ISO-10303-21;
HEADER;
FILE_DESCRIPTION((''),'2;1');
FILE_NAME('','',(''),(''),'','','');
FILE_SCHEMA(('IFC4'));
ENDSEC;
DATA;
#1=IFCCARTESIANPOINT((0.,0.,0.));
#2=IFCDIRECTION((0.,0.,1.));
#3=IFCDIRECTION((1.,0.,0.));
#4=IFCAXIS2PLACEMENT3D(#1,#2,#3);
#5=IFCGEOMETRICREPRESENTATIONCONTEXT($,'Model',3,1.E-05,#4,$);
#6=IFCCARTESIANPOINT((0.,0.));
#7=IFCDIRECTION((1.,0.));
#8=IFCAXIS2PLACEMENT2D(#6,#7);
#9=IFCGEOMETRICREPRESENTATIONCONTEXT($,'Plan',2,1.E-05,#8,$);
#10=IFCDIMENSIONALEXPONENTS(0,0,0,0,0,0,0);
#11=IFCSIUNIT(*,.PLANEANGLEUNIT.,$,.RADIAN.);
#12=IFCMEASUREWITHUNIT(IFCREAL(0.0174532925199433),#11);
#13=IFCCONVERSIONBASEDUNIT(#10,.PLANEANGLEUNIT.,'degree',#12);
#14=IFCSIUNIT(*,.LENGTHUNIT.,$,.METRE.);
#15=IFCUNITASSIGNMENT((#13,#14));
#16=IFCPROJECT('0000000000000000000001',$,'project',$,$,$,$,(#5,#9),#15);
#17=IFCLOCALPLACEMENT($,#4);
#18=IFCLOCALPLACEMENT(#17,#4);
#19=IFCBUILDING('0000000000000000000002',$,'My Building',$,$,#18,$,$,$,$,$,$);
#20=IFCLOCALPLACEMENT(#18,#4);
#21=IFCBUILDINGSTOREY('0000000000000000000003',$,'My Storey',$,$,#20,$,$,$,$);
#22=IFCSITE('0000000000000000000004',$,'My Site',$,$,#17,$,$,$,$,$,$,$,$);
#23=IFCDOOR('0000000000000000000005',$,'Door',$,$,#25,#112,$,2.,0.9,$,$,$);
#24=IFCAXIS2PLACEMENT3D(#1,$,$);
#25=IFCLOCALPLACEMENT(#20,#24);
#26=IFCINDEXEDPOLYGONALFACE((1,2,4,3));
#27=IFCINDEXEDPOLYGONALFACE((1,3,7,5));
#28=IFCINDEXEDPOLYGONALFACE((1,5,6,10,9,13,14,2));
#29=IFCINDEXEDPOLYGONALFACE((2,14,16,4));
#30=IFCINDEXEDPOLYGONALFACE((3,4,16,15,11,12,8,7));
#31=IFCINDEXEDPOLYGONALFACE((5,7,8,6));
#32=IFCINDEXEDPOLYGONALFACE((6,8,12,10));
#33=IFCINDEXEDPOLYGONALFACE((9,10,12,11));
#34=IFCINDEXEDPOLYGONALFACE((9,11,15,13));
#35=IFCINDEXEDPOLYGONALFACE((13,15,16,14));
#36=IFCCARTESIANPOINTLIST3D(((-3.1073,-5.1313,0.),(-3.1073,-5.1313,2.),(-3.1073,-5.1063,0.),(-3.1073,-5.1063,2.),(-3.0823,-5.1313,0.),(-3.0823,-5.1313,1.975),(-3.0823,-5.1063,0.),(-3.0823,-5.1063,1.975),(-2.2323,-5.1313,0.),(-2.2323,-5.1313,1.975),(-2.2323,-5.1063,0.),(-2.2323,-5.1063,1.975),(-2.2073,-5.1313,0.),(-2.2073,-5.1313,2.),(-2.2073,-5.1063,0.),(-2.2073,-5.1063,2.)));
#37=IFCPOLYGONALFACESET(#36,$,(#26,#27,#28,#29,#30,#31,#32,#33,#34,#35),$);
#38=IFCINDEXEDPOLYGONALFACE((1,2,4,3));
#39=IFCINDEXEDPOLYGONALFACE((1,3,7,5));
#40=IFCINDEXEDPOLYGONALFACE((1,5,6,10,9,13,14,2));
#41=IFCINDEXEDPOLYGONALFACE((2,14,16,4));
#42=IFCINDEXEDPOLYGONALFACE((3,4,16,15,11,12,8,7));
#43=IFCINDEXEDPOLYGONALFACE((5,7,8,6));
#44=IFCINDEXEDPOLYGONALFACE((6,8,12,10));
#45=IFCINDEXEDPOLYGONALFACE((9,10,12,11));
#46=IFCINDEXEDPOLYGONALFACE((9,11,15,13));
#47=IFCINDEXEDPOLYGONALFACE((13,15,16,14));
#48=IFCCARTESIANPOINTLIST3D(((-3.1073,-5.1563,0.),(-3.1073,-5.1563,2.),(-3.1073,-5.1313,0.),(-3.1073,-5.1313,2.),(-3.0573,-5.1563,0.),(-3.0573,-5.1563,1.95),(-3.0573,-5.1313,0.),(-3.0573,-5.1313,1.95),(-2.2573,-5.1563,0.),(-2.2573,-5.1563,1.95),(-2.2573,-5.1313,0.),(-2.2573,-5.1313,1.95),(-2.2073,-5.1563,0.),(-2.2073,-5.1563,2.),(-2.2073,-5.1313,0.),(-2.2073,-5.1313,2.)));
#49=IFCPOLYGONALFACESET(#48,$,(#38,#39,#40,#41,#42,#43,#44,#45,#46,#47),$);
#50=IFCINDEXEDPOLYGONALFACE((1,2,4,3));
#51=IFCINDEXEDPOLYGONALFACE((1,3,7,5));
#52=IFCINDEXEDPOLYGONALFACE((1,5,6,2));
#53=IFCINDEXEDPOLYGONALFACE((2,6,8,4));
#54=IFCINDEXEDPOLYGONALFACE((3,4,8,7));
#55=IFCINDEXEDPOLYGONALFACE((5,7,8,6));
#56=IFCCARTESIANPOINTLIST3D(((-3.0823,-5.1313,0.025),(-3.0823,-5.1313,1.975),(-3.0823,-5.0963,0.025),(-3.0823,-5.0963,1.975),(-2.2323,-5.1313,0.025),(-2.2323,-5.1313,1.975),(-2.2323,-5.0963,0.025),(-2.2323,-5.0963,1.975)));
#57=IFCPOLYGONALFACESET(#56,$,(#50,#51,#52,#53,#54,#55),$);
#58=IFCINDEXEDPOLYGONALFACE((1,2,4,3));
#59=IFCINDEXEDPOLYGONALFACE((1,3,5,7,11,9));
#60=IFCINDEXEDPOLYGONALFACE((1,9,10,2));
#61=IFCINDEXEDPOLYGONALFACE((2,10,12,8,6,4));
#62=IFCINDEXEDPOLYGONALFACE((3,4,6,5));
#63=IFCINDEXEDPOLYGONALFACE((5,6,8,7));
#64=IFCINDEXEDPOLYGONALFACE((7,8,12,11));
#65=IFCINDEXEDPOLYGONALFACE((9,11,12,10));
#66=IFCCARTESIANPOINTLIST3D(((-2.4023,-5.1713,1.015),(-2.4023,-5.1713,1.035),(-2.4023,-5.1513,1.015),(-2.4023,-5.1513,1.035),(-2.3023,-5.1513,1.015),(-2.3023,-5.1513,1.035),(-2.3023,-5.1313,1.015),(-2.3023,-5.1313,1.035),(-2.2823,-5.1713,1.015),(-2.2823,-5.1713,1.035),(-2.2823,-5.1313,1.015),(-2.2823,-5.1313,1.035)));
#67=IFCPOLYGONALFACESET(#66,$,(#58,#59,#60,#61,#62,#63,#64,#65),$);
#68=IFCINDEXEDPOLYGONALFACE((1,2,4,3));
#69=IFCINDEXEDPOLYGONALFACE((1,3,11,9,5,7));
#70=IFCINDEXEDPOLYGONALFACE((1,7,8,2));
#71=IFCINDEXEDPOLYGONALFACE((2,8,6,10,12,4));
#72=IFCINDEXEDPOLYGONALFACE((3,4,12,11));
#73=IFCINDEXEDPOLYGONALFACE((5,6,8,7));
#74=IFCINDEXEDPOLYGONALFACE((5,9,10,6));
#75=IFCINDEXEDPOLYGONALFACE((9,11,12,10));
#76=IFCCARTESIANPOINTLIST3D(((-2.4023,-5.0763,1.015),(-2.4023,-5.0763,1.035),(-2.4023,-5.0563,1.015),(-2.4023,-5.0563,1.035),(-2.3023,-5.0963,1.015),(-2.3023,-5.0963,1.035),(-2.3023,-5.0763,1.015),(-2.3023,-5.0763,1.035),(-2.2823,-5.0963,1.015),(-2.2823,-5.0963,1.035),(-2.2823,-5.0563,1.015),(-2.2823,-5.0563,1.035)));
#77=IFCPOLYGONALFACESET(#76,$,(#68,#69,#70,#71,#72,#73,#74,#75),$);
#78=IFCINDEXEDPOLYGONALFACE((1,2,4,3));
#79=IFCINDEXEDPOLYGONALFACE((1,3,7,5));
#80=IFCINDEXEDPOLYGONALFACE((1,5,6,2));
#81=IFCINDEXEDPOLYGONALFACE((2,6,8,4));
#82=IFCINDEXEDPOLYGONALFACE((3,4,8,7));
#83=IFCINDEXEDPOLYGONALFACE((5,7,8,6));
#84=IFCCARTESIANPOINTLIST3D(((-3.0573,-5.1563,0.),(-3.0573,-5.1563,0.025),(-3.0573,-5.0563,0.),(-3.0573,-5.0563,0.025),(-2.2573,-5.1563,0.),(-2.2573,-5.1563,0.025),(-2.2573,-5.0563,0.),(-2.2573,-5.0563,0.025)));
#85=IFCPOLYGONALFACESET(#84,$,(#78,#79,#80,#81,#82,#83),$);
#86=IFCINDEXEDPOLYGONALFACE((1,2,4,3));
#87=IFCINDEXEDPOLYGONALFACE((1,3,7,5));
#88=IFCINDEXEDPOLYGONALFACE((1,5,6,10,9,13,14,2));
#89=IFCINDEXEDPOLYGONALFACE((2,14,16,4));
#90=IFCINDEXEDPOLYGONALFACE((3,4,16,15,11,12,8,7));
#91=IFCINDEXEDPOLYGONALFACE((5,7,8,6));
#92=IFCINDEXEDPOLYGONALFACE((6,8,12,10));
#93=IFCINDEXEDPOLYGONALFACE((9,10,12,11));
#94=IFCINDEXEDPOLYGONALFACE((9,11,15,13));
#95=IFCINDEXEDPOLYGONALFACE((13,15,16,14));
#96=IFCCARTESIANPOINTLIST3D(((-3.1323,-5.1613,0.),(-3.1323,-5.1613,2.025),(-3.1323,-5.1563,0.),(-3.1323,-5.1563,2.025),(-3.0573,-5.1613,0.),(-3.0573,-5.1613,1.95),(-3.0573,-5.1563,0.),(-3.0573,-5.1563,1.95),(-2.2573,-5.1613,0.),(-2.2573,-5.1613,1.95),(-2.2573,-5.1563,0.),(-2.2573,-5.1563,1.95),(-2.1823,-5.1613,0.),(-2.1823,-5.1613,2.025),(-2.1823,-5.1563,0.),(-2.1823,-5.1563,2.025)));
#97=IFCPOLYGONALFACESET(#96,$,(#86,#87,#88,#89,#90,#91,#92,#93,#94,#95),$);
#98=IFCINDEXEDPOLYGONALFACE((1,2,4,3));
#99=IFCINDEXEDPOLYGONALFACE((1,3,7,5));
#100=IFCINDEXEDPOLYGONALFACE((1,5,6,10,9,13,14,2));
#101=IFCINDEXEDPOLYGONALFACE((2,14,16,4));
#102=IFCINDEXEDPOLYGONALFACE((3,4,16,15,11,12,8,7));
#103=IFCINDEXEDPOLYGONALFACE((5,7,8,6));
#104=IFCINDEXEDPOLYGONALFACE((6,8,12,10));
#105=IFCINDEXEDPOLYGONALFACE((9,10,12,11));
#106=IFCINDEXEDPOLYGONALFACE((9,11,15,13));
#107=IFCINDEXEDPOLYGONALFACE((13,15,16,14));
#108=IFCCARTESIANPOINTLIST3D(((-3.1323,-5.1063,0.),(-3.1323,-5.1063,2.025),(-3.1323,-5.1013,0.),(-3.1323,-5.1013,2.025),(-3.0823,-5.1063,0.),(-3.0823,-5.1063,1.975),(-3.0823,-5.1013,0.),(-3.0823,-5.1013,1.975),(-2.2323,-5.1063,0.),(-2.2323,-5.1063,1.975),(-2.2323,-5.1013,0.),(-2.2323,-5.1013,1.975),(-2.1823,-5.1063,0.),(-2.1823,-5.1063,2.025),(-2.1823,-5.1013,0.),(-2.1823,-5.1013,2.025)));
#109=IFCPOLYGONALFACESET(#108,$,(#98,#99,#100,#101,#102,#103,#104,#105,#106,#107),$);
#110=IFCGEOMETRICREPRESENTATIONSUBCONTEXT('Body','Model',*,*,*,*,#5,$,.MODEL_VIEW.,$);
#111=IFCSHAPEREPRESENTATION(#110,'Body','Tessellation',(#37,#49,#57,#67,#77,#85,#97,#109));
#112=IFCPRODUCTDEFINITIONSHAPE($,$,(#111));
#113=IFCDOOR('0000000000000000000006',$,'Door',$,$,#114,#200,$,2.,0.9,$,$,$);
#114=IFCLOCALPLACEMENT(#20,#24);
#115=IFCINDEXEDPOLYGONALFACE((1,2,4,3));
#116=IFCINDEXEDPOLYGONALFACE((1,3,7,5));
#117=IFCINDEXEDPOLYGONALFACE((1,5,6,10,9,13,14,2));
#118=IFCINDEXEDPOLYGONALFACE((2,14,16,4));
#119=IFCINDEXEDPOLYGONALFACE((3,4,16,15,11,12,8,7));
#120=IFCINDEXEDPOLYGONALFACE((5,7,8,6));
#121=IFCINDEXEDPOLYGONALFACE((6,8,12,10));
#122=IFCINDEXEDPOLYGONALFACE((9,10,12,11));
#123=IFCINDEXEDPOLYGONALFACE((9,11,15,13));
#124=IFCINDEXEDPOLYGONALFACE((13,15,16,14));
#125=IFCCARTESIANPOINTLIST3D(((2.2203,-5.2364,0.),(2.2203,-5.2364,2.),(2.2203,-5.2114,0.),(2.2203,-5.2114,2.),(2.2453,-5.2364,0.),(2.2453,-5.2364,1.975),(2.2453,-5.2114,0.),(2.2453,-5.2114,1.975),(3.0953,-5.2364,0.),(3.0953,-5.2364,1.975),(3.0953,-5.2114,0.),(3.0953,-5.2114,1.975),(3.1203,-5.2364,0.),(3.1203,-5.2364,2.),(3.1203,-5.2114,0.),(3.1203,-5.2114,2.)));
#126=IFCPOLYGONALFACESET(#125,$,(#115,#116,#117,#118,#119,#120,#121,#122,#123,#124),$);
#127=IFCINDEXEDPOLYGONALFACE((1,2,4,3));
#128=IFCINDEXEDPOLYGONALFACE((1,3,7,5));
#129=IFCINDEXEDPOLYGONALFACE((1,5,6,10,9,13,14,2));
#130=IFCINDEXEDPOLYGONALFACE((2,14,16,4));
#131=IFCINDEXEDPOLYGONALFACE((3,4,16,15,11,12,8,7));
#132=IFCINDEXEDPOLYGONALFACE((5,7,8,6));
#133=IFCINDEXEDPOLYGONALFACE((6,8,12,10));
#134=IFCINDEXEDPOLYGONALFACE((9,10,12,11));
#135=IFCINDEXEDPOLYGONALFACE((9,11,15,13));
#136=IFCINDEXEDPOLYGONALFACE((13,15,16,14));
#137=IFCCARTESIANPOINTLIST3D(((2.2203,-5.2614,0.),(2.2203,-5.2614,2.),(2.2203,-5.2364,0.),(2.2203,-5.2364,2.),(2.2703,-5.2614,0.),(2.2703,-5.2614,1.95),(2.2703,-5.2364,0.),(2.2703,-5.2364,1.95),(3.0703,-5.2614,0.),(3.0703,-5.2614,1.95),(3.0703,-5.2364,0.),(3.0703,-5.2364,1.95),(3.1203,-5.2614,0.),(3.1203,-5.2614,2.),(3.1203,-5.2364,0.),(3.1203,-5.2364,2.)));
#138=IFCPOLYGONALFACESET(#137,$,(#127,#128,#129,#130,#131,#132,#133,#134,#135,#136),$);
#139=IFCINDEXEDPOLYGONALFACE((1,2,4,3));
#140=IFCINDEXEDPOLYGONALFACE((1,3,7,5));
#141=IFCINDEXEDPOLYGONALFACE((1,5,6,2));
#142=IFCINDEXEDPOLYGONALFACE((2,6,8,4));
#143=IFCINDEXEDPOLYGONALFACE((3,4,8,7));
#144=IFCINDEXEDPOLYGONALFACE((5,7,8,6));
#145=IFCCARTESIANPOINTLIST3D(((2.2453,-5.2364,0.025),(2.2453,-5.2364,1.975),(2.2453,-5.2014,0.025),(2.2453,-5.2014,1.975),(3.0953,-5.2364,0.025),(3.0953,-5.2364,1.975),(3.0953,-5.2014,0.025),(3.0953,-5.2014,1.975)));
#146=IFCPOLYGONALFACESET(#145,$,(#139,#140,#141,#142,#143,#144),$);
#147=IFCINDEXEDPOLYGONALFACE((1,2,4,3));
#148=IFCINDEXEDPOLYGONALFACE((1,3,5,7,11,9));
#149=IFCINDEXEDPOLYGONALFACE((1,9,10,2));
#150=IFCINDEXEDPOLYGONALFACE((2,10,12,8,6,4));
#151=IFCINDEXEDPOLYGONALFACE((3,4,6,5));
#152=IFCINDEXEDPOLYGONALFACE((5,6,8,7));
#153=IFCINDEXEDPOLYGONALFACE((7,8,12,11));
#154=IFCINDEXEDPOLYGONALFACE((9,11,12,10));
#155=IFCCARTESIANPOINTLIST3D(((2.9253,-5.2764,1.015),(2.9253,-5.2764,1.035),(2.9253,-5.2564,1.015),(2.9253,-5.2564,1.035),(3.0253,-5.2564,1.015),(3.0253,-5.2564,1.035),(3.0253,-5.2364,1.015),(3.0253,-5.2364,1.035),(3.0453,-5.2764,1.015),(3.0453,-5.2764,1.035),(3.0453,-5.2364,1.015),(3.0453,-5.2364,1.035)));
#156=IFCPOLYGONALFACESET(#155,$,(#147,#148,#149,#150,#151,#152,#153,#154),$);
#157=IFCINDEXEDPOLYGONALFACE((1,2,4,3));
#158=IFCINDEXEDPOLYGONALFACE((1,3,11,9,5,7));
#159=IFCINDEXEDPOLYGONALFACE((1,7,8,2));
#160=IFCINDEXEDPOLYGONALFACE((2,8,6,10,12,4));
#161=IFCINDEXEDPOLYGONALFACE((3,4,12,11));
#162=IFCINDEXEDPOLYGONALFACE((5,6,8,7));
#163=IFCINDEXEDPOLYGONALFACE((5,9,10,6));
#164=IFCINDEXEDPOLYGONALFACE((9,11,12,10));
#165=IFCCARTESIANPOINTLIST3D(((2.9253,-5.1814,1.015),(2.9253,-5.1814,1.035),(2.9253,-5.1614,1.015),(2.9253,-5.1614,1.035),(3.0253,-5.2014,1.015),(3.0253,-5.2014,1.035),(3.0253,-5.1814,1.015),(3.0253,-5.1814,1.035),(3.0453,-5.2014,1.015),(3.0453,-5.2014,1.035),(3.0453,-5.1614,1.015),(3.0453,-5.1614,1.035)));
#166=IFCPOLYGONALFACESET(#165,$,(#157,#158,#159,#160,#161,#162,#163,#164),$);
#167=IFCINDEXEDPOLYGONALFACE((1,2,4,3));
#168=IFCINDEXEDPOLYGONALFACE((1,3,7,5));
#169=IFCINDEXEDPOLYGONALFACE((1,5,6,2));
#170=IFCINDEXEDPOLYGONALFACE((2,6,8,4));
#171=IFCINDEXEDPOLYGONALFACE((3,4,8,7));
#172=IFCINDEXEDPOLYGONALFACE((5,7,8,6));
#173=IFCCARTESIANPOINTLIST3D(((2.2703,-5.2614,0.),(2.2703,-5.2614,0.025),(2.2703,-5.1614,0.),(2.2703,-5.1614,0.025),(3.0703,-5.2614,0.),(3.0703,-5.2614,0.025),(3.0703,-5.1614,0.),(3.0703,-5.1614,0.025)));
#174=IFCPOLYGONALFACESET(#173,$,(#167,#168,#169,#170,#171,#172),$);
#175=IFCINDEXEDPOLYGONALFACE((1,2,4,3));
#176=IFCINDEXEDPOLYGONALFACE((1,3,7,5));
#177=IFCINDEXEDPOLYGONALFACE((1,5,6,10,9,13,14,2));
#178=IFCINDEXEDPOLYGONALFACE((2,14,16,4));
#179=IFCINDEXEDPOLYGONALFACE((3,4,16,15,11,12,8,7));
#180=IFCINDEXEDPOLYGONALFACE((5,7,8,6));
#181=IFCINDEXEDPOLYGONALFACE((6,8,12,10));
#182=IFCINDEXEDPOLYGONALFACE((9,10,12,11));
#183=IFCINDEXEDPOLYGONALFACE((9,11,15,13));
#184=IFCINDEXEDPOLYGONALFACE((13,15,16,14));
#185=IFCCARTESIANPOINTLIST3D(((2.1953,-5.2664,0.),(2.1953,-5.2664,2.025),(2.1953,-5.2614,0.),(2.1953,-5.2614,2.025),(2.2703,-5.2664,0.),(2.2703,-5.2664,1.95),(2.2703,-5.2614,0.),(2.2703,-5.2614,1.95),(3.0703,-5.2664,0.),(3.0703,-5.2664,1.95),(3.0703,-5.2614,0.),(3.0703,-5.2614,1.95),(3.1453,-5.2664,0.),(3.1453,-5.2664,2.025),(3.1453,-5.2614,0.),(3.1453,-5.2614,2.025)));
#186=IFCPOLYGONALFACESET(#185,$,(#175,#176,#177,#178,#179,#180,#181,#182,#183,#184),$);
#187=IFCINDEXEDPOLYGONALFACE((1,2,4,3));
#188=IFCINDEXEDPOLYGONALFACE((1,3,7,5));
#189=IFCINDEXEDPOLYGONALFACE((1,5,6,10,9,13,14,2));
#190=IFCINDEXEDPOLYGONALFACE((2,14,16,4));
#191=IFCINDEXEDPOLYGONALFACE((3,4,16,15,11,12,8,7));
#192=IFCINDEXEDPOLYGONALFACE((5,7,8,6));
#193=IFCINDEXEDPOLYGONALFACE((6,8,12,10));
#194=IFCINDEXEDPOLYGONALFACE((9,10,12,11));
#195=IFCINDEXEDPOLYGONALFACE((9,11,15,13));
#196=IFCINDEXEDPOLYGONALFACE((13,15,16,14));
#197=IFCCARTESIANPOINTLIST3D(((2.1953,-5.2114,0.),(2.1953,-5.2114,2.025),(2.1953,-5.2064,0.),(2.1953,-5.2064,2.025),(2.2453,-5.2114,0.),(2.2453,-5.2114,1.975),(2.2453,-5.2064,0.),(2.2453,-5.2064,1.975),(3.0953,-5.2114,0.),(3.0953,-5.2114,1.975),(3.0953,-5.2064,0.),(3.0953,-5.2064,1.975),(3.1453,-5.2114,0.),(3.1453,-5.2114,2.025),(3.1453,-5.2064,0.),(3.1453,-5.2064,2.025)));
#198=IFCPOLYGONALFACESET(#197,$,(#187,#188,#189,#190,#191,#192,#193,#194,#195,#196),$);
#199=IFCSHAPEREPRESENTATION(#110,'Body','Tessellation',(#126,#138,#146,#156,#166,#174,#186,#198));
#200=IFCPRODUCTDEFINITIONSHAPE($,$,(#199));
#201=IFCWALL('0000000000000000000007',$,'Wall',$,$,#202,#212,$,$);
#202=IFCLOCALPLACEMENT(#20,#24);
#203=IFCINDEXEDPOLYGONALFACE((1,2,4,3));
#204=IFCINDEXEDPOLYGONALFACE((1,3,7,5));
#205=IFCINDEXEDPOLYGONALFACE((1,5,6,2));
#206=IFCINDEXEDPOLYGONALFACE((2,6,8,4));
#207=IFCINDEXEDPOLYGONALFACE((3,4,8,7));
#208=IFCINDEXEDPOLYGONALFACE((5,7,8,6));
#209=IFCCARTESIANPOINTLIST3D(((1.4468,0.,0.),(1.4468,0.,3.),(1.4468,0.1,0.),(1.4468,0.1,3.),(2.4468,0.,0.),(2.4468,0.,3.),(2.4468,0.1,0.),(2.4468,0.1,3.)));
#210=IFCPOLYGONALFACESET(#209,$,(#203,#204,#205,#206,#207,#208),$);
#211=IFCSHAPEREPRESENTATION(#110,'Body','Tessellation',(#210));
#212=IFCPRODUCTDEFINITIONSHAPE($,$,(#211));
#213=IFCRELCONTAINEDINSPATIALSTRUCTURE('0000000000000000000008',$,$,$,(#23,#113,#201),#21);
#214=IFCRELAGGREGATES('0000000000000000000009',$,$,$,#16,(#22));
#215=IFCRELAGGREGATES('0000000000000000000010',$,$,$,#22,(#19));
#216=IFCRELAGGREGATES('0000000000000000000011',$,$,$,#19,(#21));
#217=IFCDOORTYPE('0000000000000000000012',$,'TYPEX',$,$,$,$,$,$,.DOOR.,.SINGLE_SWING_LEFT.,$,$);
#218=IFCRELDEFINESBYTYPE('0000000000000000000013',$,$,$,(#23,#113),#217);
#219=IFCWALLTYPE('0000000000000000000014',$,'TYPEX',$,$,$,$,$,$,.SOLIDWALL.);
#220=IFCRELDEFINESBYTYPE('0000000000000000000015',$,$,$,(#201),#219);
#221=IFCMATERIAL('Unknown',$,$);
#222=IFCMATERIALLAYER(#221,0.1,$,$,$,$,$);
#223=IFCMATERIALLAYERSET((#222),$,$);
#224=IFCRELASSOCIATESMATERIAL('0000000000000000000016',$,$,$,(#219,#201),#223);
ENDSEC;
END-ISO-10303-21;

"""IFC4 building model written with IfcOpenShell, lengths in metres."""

from ifc_helpers import new_model, entity, si_unit, converted_unit, frame, origin_with_axes, origin_2d_with_axis, place, context, subcontext, project, spatial, line, indexed_curve, outline, extrude, shape, source, transform, mapped, material, layer, layer_set, layer_usage, type_object, type_shapes, element, save


model = new_model("IFC4")

# Units and contexts
model_context = context("Model", 3, precision=1e-05, world=origin_with_axes())
plan_context = context("Plan", 2, precision=1e-05, world=origin_2d_with_axis())
body_context_1 = subcontext(model_context, "Body", "Model", "MODEL_VIEW")
body_context_2 = subcontext(plan_context, "Body", "Plan", "PLAN_VIEW")
ifc_project = project(units=[converted_unit("PLANEANGLEUNIT", "degree", entity("IfcReal", 0.0174532925199433), si_unit("PLANEANGLEUNIT", "RADIAN"), dimensions=[0, 0, 0, 0, 0, 0, 0]), si_unit("LENGTHUNIT", "METRE")], contexts=[model_context, plan_context])

# Site, building, storey
site_placement = place(None, origin_with_axes())
site = spatial("IfcSite", under=ifc_project, at=site_placement, Name="My Site")
building_placement = place(site_placement, origin_with_axes())
building = spatial("IfcBuilding", under=site, at=building_placement, Name="My Building")
storey_placement = place(building_placement, origin_with_axes())
storey = spatial("IfcBuildingStorey", under=building, at=storey_placement, Name="My Storey")

# Doors
door_type = type_object("IfcDoorType", Name="TYPEX", OperationType="SINGLE_SWING_LEFT", PredefinedType="DOOR")
shared_shape_1 = source(origin_with_axes(), body_context_1, "Body", "SweptSolid", [
    extrude(outline(indexed_curve([(0.0, 0.0), (0.0, 2.0), (0.9, 2.0), (0.9, 0.0), (0.875, 0.0), (0.875, 1.975), (0.025, 1.975), (0.025, 0.0)], segments=[line(1, 2, 3, 4, 5, 6, 7, 8, 1)])), frame((0.0, 0.025, 0.0), z_axis=(0.0, -1.0, 0.0), x_axis=(1.0, 0.0, 0.0)), (0.0, 0.0, -1.0), 0.025),
    extrude(outline(indexed_curve([(0.0, 0.0), (0.0, 2.0), (0.9, 2.0), (0.9, 0.0), (0.85, 0.0), (0.85, 1.95), (0.05, 1.95), (0.05, 0.0)], segments=[line(1, 2, 3, 4, 5, 6, 7, 8, 1)])), frame((0.0, 0.0, 0.0), z_axis=(0.0, -1.0, 0.0), x_axis=(1.0, 0.0, 0.0)), (0.0, 0.0, -1.0), 0.025),
    extrude(outline(indexed_curve([(0.0, 0.0), (0.85, 0.0), (0.85, 0.035), (0.0, 0.035)], segments=[line(1, 2, 3, 4, 1)])), frame((0.025, 0.025, 0.025), z_axis=(0.0, 0.0, 1.0), x_axis=(1.0, 0.0, 0.0)), (0.0, 0.0, 1.0), 1.95),
    extrude(outline(indexed_curve([(0.0, 0.0), (0.0, -0.04), (-0.12, -0.04), (-0.12, -0.02), (-0.02, -0.02), (-0.02, 0.0)], segments=[line(1, 2, 3, 4, 5, 6, 1)])), frame((0.825, 0.025, 1.015), z_axis=(0.0, 0.0, 1.0), x_axis=(1.0, 0.0, 0.0)), (0.0, 0.0, 1.0), 0.02),
    extrude(outline(indexed_curve([(0.0, 0.0), (0.0, 0.04), (-0.12, 0.04), (-0.12, 0.02), (-0.02, 0.02), (-0.02, 0.0)], segments=[line(1, 2, 3, 4, 5, 6, 1)])), frame((0.825, 0.06, 1.015), z_axis=(0.0, 0.0, 1.0), x_axis=(1.0, 0.0, 0.0)), (0.0, 0.0, 1.0), 0.02),
    extrude(outline(indexed_curve([(0.0, 0.0), (0.8, 0.0), (0.8, 0.1), (0.0, 0.1)], segments=[line(1, 2, 3, 4, 1)])), frame((0.05, 0.0, 0.0), z_axis=(0.0, 0.0, 1.0), x_axis=(1.0, 0.0, 0.0)), (0.0, 0.0, 1.0), 0.025),
    extrude(outline(indexed_curve([(0.0, 0.0), (0.0, 2.025), (0.95, 2.025), (0.95, 0.0), (0.875, 0.0), (0.875, 1.95), (0.075, 1.95), (0.075, 0.0)], segments=[line(1, 2, 3, 4, 5, 6, 7, 8, 1)])), frame((-0.025, -0.005, 0.0), z_axis=(0.0, -1.0, 0.0), x_axis=(1.0, 0.0, 0.0)), (0.0, 0.0, -1.0), 0.005),
    extrude(outline(indexed_curve([(0.0, 0.0), (0.0, 2.025), (0.95, 2.025), (0.95, 0.0), (0.9, 0.0), (0.9, 1.975), (0.05, 1.975), (0.05, 0.0)], segments=[line(1, 2, 3, 4, 5, 6, 7, 8, 1)])), frame((-0.025, 0.05, 0.0), z_axis=(0.0, -1.0, 0.0), x_axis=(1.0, 0.0, 0.0)), (0.0, 0.0, -1.0), 0.005),
])
shared_shape_2 = source(origin_with_axes(), body_context_2, "Body", "Curve2D", [
    entity("IfcIndexedPolyCurve", entity("IfcCartesianPointList2D", [[0.0, 0.0], [0.0, 0.05], [0.025, 0.05], [0.025, 0.025], [0.05, 0.025], [0.05, 0.0]]), [entity("IfcLineIndex", [1, 2, 3, 4, 5, 6, 1])]),
    entity("IfcIndexedPolyCurve", entity("IfcCartesianPointList2D", [[0.9, 0.0], [0.9, 0.05], [0.875, 0.05], [0.875, 0.025], [0.85, 0.025], [0.85, 0.0]]), [entity("IfcLineIndex", [1, 2, 3, 4, 5, 6, 1])]),
    entity("IfcTrimmedCurve", entity("IfcEllipse", entity("IfcAxis2Placement2D", entity("IfcCartesianPoint", [0.06, 0.05]), entity("IfcDirection", [1.0, 0.0])), 0.815, 0.85), [entity("IfcCartesianPoint", [0.875, 0.05])], [entity("IfcCartesianPoint", [0.06, 0.9])], True, "CARTESIAN"),
    entity("IfcIndexedPolyCurve", entity("IfcCartesianPointList2D", [[0.025, 0.05], [0.06, 0.05], [0.06, 0.9], [0.025, 0.9]]), [entity("IfcLineIndex", [1, 2, 3, 4, 1])]),
])
type_shapes(door_type, [shared_shape_1, shared_shape_2])
for number, where, z_axis, x_axis, name in (
    (1, (-3.1073, -5.1563, 0.0), (0.0, 0.0, 1.0), (1.0, 0.0, 0.0), "Door"),
    (2, (2.2203, -5.2614, 0.0), (0.0, 0.0, 1.0), (1.0, 0.0, 0.0), "Door"),
):
    element("IfcDoor", number, at=place(storey_placement, frame(where, z_axis=z_axis, x_axis=x_axis)), inside=storey, type_object=door_type, Name=name, OverallHeight=2.0, OverallWidth=0.9, shapes=[
        shape(body_context_1, "Body", "MappedRepresentation", [mapped(shared_shape_1, transform((0.0, 0.0, 0.0), x_axis=(1.0, 0.0, 0.0), y_axis=(0.0, 1.0, 0.0), z_axis=(0.0, 0.0, 1.0), scale=1.0))]),
        shape(body_context_2, "Body", "MappedRepresentation", [mapped(shared_shape_2, transform((0.0, 0.0, 0.0), x_axis=(1.0, 0.0, 0.0), y_axis=(0.0, 1.0, 0.0), z_axis=(0.0, 0.0, 1.0), scale=1.0))]),
    ])

# Wall
ifc_material = material(Name="Unknown")
ifc_layer = layer(ifc_material, 0.1)
ifc_layer_set = layer_set([ifc_layer])
ifc_layer_usage_1 = layer_usage(ifc_layer_set, "AXIS2", "POSITIVE", 0.0)
wall_type = type_object("IfcWallType", Name="TYPEX", PredefinedType="SOLIDWALL", material=ifc_layer_set)
wall_1_placement = place(storey_placement, frame((1.4468, 0.0, 0.0), z_axis=(0.0, 0.0, 1.0), x_axis=(1.0, 0.0, 0.0)))
element("IfcWall", 3, at=wall_1_placement, inside=storey, type_object=wall_type, material=ifc_layer_usage_1, Name="Wall", context=body_context_1, shape_type="SweptSolid", body=[
    extrude(outline(indexed_curve([(0.0, 0.0), (0.0, 0.1), (1.0, 0.1), (1.0, 0.0), (0.0, 0.0)], self_intersect=False)), origin_with_axes(), (0.0, 0.0, 1.0), 3.0),
])

save(model, "model.ifc")
